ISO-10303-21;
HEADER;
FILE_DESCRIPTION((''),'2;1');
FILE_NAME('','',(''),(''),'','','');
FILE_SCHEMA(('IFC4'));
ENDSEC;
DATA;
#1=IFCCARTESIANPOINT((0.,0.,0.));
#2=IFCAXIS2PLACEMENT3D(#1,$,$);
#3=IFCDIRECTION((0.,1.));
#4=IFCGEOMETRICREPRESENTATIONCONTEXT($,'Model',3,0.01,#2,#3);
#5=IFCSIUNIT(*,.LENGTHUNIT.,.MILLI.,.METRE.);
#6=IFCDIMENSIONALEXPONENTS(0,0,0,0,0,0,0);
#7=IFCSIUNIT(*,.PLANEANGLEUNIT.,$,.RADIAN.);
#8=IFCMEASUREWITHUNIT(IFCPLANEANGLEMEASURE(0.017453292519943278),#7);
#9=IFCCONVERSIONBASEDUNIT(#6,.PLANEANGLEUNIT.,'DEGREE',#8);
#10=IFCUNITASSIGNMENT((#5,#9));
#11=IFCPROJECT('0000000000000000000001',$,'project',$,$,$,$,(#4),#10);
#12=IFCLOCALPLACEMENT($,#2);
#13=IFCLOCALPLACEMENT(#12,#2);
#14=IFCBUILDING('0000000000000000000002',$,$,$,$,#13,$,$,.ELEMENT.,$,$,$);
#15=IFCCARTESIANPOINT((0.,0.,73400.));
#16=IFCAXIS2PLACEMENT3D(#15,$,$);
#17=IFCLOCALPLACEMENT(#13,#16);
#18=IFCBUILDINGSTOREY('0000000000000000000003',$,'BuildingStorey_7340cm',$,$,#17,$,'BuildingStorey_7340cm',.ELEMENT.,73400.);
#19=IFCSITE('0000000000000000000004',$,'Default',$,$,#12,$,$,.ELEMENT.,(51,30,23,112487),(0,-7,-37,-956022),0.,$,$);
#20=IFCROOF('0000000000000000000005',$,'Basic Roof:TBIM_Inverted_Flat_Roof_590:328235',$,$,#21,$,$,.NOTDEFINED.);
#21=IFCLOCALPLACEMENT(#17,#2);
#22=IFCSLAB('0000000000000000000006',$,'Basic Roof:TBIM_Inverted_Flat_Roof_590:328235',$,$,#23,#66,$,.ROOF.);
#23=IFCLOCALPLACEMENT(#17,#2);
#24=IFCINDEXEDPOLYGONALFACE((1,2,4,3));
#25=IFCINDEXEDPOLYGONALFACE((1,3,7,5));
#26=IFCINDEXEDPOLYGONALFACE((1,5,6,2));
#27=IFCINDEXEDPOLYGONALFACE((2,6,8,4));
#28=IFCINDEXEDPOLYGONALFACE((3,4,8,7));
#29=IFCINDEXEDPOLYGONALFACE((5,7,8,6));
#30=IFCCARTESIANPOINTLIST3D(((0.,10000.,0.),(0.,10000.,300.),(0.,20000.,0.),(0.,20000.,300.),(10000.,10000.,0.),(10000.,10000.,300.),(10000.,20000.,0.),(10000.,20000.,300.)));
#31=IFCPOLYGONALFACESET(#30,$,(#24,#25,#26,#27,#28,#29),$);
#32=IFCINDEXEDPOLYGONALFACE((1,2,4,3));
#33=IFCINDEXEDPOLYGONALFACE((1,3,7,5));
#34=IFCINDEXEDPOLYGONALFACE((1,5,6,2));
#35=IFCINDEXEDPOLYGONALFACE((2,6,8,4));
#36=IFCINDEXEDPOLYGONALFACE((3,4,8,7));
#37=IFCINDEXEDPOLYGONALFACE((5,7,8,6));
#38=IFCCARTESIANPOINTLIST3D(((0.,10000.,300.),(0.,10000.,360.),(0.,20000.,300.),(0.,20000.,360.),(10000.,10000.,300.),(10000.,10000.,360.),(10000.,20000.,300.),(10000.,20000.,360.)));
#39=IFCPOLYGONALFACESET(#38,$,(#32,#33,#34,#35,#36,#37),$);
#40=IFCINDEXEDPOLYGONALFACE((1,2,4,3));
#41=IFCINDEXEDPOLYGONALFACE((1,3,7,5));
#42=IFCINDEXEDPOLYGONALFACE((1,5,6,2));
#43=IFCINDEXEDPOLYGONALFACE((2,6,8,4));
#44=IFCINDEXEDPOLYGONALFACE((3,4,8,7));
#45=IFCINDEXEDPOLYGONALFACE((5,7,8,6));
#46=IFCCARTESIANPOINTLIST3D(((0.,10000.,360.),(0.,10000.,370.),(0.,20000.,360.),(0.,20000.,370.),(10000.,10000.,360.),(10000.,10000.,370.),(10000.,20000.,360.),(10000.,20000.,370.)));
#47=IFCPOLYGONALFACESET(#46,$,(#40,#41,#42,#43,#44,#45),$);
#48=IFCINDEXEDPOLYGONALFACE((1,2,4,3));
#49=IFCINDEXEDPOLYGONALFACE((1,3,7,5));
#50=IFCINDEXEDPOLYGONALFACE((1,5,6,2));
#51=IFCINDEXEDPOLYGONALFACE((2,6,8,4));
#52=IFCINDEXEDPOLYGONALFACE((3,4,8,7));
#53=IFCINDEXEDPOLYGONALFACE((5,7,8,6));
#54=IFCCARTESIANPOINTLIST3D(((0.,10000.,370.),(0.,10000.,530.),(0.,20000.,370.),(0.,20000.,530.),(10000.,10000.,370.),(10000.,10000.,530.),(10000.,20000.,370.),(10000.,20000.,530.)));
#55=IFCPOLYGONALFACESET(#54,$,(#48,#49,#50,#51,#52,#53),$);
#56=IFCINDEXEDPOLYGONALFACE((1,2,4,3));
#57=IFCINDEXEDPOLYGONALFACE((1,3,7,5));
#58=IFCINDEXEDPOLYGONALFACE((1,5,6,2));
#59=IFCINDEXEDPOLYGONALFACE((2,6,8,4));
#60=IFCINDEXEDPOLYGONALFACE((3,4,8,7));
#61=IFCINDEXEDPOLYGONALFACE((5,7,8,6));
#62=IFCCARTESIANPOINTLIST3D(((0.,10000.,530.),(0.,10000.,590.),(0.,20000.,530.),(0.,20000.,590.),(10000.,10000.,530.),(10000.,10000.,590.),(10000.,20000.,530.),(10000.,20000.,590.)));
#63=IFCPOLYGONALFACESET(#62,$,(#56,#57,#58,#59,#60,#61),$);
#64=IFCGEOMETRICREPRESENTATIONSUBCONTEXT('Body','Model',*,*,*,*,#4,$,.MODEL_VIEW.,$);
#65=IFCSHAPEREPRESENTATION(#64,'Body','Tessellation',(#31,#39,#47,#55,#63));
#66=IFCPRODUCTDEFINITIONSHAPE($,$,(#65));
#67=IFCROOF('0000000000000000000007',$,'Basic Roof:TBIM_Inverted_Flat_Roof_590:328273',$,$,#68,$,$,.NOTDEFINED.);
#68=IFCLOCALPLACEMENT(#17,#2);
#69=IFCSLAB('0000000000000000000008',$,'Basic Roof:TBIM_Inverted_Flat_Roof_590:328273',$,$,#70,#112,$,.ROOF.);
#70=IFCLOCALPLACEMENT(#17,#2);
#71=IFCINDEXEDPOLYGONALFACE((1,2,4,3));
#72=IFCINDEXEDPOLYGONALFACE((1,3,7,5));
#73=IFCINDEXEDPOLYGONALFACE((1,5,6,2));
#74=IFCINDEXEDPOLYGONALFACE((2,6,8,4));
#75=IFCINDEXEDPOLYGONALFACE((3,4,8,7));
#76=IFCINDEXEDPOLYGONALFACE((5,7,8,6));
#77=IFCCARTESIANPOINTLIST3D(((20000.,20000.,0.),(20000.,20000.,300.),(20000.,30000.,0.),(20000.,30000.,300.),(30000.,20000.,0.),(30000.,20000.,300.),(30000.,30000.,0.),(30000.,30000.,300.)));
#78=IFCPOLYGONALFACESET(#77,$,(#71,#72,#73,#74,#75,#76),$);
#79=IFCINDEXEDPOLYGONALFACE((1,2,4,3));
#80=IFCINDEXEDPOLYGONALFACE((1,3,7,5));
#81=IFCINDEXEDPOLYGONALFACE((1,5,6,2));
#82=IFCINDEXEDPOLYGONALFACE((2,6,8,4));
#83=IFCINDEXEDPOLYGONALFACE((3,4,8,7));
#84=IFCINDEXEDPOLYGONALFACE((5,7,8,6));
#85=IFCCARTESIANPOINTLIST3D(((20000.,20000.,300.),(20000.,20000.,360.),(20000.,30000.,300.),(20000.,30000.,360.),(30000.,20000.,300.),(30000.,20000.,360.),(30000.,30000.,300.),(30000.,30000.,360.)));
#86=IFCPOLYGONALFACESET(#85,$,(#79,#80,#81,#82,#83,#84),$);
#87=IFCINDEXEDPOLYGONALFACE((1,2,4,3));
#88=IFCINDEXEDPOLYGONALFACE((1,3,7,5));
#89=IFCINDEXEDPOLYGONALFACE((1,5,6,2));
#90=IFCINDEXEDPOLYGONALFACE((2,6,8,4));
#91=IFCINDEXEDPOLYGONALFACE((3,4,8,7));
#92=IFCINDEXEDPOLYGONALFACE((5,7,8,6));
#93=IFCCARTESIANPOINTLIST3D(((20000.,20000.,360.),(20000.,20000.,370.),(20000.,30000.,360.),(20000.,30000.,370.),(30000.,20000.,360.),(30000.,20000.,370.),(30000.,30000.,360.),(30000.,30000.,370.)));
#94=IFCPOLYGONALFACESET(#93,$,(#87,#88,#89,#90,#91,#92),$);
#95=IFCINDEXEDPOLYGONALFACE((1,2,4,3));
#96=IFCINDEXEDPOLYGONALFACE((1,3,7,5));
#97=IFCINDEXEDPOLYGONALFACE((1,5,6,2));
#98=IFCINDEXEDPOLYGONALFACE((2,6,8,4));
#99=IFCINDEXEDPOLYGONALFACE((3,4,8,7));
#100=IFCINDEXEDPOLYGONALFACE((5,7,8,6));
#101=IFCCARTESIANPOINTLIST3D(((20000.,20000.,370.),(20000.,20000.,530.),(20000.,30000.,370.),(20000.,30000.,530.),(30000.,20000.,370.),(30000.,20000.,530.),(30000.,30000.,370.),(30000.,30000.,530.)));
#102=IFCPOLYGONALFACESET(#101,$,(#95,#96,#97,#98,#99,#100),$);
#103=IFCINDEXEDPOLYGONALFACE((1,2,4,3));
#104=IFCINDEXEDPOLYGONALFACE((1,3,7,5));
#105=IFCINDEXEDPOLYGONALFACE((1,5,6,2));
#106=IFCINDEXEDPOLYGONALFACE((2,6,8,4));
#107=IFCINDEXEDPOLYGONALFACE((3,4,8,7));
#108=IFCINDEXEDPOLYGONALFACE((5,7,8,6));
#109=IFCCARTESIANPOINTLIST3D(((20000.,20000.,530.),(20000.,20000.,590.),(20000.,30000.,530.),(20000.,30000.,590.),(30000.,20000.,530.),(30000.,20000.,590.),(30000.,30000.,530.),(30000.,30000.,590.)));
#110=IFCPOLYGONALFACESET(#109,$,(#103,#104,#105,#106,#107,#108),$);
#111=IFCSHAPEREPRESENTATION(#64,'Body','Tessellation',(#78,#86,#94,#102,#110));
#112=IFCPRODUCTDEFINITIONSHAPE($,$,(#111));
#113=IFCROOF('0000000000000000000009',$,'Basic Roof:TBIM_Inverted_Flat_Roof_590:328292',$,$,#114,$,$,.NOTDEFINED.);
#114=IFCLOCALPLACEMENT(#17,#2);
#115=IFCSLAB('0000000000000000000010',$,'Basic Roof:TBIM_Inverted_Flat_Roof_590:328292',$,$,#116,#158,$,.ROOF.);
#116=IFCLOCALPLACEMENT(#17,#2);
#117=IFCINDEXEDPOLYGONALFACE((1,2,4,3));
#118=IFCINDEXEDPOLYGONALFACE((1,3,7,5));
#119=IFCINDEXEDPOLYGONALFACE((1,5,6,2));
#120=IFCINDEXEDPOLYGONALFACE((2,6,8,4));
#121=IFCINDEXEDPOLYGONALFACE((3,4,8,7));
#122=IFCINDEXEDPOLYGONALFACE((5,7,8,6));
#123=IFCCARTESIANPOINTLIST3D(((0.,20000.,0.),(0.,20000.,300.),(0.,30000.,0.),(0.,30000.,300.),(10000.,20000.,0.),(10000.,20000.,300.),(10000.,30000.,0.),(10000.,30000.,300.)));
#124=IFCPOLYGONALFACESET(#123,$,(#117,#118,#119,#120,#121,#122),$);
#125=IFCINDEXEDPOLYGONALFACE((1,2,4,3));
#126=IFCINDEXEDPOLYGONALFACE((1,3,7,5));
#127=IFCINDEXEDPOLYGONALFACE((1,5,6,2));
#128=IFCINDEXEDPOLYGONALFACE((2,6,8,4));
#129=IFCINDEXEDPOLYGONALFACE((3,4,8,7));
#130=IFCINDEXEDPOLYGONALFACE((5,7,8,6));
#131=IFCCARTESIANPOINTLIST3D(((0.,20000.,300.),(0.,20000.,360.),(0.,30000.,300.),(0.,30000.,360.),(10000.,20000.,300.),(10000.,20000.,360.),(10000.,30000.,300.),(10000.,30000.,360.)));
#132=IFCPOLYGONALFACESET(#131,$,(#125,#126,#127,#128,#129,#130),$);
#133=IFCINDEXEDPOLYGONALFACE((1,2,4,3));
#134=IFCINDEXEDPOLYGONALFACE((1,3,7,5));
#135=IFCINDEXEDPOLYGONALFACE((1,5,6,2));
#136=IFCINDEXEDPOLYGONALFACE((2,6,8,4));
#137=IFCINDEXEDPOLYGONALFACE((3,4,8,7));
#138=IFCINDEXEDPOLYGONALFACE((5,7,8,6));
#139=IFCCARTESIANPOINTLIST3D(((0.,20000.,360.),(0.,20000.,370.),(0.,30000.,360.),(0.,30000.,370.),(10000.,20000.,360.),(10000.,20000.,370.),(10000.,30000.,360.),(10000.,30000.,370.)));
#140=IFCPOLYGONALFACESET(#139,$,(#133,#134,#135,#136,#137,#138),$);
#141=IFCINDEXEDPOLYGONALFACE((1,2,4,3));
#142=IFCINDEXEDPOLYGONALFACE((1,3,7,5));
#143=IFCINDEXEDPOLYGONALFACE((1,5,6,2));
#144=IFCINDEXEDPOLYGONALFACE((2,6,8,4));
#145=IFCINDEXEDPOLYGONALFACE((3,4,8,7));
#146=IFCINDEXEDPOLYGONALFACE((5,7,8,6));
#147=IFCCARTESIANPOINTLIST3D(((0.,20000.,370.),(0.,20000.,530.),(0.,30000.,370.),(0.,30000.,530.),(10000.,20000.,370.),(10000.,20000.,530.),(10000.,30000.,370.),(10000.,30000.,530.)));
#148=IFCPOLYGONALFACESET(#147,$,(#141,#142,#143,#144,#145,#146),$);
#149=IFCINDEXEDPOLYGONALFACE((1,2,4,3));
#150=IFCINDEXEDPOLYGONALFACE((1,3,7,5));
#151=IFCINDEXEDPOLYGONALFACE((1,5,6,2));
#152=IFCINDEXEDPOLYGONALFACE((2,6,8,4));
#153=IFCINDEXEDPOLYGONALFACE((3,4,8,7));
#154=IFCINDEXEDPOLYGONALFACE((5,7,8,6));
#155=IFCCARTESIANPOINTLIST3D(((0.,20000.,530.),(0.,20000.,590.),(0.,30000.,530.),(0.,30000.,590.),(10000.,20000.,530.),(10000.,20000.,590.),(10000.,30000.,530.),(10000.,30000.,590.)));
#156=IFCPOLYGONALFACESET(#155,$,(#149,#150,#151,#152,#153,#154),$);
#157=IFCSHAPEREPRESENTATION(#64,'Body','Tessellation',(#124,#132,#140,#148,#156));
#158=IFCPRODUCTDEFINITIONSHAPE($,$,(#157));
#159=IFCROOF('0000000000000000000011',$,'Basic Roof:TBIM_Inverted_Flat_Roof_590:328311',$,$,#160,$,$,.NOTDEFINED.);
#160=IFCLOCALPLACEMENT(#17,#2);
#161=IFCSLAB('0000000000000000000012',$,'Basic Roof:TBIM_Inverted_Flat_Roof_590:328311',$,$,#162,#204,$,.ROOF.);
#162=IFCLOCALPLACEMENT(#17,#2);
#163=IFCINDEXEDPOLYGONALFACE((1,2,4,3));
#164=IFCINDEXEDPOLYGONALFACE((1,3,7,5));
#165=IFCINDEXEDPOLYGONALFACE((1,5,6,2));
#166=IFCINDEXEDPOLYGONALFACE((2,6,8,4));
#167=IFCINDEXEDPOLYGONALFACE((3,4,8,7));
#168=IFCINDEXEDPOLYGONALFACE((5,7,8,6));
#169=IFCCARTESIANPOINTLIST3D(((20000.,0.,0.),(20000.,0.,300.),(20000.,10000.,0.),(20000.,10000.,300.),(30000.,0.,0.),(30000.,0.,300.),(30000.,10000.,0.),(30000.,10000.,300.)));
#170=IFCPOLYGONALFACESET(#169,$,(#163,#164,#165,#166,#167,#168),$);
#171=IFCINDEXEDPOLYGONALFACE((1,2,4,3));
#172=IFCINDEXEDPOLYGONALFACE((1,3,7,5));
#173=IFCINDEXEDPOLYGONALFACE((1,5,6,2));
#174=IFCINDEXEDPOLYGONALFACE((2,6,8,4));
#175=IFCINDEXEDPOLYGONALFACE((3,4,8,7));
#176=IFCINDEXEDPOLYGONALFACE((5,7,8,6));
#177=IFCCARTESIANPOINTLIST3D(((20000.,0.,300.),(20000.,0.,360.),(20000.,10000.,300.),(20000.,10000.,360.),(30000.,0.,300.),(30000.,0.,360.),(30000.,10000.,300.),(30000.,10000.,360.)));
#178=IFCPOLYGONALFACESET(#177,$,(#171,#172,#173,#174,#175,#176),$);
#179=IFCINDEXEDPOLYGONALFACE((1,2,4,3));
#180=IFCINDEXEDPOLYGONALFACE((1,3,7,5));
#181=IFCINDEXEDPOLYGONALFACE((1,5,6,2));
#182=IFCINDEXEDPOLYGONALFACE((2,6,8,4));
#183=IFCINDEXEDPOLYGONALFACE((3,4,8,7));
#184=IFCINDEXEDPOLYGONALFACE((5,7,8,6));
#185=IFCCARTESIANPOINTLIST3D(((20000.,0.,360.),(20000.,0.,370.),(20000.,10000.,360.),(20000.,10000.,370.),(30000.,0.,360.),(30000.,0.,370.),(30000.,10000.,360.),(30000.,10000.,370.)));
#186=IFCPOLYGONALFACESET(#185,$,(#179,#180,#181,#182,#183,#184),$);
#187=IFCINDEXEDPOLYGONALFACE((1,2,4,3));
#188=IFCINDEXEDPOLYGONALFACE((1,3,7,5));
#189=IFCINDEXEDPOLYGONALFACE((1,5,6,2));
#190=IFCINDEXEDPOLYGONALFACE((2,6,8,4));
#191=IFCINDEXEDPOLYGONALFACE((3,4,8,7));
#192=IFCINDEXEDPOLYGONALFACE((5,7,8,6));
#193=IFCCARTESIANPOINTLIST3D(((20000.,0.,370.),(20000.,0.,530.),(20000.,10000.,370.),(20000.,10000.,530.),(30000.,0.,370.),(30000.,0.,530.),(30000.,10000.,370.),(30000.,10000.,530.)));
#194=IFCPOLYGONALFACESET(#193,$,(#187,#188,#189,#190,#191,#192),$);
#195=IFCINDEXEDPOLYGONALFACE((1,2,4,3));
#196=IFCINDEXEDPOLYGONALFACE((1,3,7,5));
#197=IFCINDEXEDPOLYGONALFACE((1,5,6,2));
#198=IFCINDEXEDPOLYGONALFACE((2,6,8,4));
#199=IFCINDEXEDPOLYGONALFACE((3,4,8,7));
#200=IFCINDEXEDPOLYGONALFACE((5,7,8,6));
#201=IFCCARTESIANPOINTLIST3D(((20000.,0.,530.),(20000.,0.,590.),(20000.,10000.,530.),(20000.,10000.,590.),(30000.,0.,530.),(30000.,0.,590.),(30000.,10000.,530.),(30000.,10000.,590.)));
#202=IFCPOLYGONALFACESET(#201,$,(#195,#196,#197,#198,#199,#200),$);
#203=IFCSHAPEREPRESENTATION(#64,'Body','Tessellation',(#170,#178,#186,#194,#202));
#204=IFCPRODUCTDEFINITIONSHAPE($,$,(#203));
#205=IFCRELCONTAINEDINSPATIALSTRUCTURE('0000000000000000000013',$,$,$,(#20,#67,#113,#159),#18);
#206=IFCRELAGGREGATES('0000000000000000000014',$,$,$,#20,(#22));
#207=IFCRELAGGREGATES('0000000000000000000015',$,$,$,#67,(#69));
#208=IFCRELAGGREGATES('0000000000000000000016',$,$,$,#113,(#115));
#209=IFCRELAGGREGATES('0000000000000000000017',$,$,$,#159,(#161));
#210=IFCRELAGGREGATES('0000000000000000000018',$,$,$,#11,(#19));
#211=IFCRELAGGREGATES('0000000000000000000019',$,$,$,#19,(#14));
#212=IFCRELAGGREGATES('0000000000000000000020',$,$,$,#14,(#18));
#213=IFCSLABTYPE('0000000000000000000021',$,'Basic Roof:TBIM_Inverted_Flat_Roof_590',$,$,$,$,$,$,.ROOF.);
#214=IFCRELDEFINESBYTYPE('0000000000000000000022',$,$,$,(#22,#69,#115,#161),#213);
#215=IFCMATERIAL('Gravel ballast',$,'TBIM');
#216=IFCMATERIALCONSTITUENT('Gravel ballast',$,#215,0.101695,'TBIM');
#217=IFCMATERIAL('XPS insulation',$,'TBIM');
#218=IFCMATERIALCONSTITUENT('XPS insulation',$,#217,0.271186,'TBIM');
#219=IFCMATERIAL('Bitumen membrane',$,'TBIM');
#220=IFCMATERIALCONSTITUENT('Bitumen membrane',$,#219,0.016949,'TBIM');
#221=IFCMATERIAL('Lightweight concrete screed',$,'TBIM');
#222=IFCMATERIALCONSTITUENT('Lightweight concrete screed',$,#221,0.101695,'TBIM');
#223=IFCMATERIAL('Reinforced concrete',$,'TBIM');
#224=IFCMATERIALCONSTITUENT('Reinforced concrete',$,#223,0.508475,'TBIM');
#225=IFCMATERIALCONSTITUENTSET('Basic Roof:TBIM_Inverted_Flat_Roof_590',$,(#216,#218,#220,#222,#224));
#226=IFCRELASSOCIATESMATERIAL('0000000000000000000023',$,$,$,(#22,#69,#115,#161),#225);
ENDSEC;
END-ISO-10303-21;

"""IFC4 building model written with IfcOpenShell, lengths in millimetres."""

from ifc_helpers import new_model, entity, si_unit, converted_unit, direction, frame, origin, place, context, subcontext, project, spatial, indexed_curve, outline, extrude, material, constituent, constituent_set, type_object, element, aggregate, save


model = new_model("IFC4")

# Units and contexts
model_context = context("Model", 3, precision=0.01, world=origin(), true_north=direction((0.0, 1.0)))
body_context = subcontext(model_context, "Body", "Model", "MODEL_VIEW")
ifc_project = project(units=[si_unit("LENGTHUNIT", "METRE", prefix="MILLI"), converted_unit("PLANEANGLEUNIT", "DEGREE", entity("IfcPlaneAngleMeasure", 0.017453292519943278), si_unit("PLANEANGLEUNIT", "RADIAN"), dimensions=[0, 0, 0, 0, 0, 0, 0])], contexts=[model_context])

# Site, building, storey
site_placement = place(None, origin())
site = spatial("IfcSite", under=ifc_project, at=site_placement, Name="Default", CompositionType="ELEMENT", RefLatitude=(51, 30, 23, 112487), RefLongitude=(0, -7, -37, -956022), RefElevation=0.0)
building_placement = place(site_placement, origin())
building = spatial("IfcBuilding", under=site, at=building_placement, CompositionType="ELEMENT")
storey_placement = place(building_placement, frame((0.0, 0.0, 73400.0)))
storey = spatial("IfcBuildingStorey", under=building, at=storey_placement, Name="BuildingStorey_7340cm", LongName="BuildingStorey_7340cm", CompositionType="ELEMENT", Elevation=73400.0)

# Shared definitions
ifc_material_1 = material(Name="Reinforced concrete", Category="TBIM")

# Roofs, slabs
ifc_material_2 = material(Name="Gravel ballast", Category="TBIM")
ifc_constituent_1 = constituent(ifc_material_2, Name="Gravel ballast", Category="TBIM", fraction=0.101695)
ifc_material_3 = material(Name="XPS insulation", Category="TBIM")
ifc_constituent_2 = constituent(ifc_material_3, Name="XPS insulation", Category="TBIM", fraction=0.271186)
ifc_material_4 = material(Name="Bitumen membrane", Category="TBIM")
ifc_constituent_3 = constituent(ifc_material_4, Name="Bitumen membrane", Category="TBIM", fraction=0.016949)
ifc_material_5 = material(Name="Lightweight concrete screed", Category="TBIM")
ifc_constituent_4 = constituent(ifc_material_5, Name="Lightweight concrete screed", Category="TBIM", fraction=0.101695)
ifc_constituent_5 = constituent(ifc_material_1, Name="Reinforced concrete", Category="TBIM", fraction=0.508475)
ifc_constituent_set_1 = constituent_set(constituents=[ifc_constituent_1, ifc_constituent_2, ifc_constituent_3, ifc_constituent_4, ifc_constituent_5], Name="Basic Roof:TBIM_Inverted_Flat_Roof_590")
slab_type_1 = type_object("IfcSlabType", Name="Basic Roof:TBIM_Inverted_Flat_Roof_590", PredefinedType="ROOF")
roof_1_placement = place(storey_placement, frame((0.0, 10000.0, 0.0)))
roof_1 = element("IfcRoof", 1, at=roof_1_placement, inside=storey, Name="Basic Roof:TBIM_Inverted_Flat_Roof_590:328235", PredefinedType="NOTDEFINED")
slab_1_placement = place(roof_1_placement, origin())
slab_1 = element("IfcSlab", 2, at=slab_1_placement, type_object=slab_type_1, material=ifc_constituent_set_1, Name="Basic Roof:TBIM_Inverted_Flat_Roof_590:328235", PredefinedType="ROOF", context=body_context, shape_type="SweptSolid", body=[
    extrude(outline(indexed_curve([(5000.0, 5000.0), (-5000.0, 5000.0), (-5000.0, -5000.0), (5000.0, -5000.0), (5000.0, 5000.0)], self_intersect=False)), frame((5000.0, 5000.0, 0.0)), (0.0, 0.0, 1.0), 300.0),
    extrude(outline(indexed_curve([(5000.0, 5000.0), (-5000.0, 5000.0), (-5000.0, -5000.0), (5000.0, -5000.0), (5000.0, 5000.0)], self_intersect=False)), frame((5000.0, 5000.0, 300.0)), (0.0, 0.0, 1.0), 60.0),
    extrude(outline(indexed_curve([(5000.0, 5000.0), (-5000.0, 5000.0), (-5000.0, -5000.0), (5000.0, -5000.0), (5000.0, 5000.0)], self_intersect=False)), frame((5000.0, 5000.0, 360.0)), (0.0, 0.0, 1.0), 10.0),
    extrude(outline(indexed_curve([(5000.0, 5000.0), (-5000.0, 5000.0), (-5000.0, -5000.0), (5000.0, -5000.0), (5000.0, 5000.0)], self_intersect=False)), frame((5000.0, 5000.0, 370.0)), (0.0, 0.0, 1.0), 160.0),
    extrude(outline(indexed_curve([(5000.0, 5000.0), (-5000.0, 5000.0), (-5000.0, -5000.0), (5000.0, -5000.0), (5000.0, 5000.0)], self_intersect=False)), frame((5000.0, 5000.0, 530.0)), (0.0, 0.0, 1.0), 60.0),
])
aggregate(roof_1, [slab_1])
roof_2_placement = place(storey_placement, frame((20000.0, 20000.0, 0.0)))
roof_2 = element("IfcRoof", 3, at=roof_2_placement, inside=storey, Name="Basic Roof:TBIM_Inverted_Flat_Roof_590:328273", PredefinedType="NOTDEFINED")
slab_2_placement = place(roof_2_placement, origin())
slab_2 = element("IfcSlab", 4, at=slab_2_placement, type_object=slab_type_1, material=ifc_constituent_set_1, Name="Basic Roof:TBIM_Inverted_Flat_Roof_590:328273", PredefinedType="ROOF", context=body_context, shape_type="SweptSolid", body=[
    extrude(outline(indexed_curve([(-5000.0, 5000.0), (-5000.0, -5000.0), (5000.0, -5000.0), (5000.0, 5000.0), (-5000.0, 5000.0)], self_intersect=False)), frame((5000.0, 5000.0, 0.0)), (0.0, 0.0, 1.0), 300.0),
    extrude(outline(indexed_curve([(-5000.0, 5000.0), (-5000.0, -5000.0), (5000.0, -5000.0), (5000.0, 5000.0), (-5000.0, 5000.0)], self_intersect=False)), frame((5000.0, 5000.0, 300.0)), (0.0, 0.0, 1.0), 60.0),
    extrude(outline(indexed_curve([(-5000.0, 5000.0), (-5000.0, -5000.0), (5000.0, -5000.0), (5000.0, 5000.0), (-5000.0, 5000.0)], self_intersect=False)), frame((5000.0, 5000.0, 360.0)), (0.0, 0.0, 1.0), 10.0),
    extrude(outline(indexed_curve([(-5000.0, 5000.0), (-5000.0, -5000.0), (5000.0, -5000.0), (5000.0, 5000.0), (-5000.0, 5000.0)], self_intersect=False)), frame((5000.0, 5000.0, 370.0)), (0.0, 0.0, 1.0), 160.0),
    extrude(outline(indexed_curve([(-5000.0, 5000.0), (-5000.0, -5000.0), (5000.0, -5000.0), (5000.0, 5000.0), (-5000.0, 5000.0)], self_intersect=False)), frame((5000.0, 5000.0, 530.0)), (0.0, 0.0, 1.0), 60.0),
])
aggregate(roof_2, [slab_2])
roof_3_placement = place(storey_placement, frame((0.0, 20000.0, 0.0)))
roof_3 = element("IfcRoof", 5, at=roof_3_placement, inside=storey, Name="Basic Roof:TBIM_Inverted_Flat_Roof_590:328292", PredefinedType="NOTDEFINED")
slab_3_placement = place(roof_3_placement, origin())
slab_3 = element("IfcSlab", 6, at=slab_3_placement, type_object=slab_type_1, material=ifc_constituent_set_1, Name="Basic Roof:TBIM_Inverted_Flat_Roof_590:328292", PredefinedType="ROOF", context=body_context, shape_type="SweptSolid", body=[
    extrude(outline(indexed_curve([(-5000.0, 5000.0), (-5000.0, -5000.0), (5000.0, -5000.0), (5000.0, 5000.0), (-5000.0, 5000.0)], self_intersect=False)), frame((5000.0, 5000.0, 0.0)), (0.0, 0.0, 1.0), 300.0),
    extrude(outline(indexed_curve([(-5000.0, 5000.0), (-5000.0, -5000.0), (5000.0, -5000.0), (5000.0, 5000.0), (-5000.0, 5000.0)], self_intersect=False)), frame((5000.0, 5000.0, 300.0)), (0.0, 0.0, 1.0), 60.0),
    extrude(outline(indexed_curve([(-5000.0, 5000.0), (-5000.0, -5000.0), (5000.0, -5000.0), (5000.0, 5000.0), (-5000.0, 5000.0)], self_intersect=False)), frame((5000.0, 5000.0, 360.0)), (0.0, 0.0, 1.0), 10.0),
    extrude(outline(indexed_curve([(-5000.0, 5000.0), (-5000.0, -5000.0), (5000.0, -5000.0), (5000.0, 5000.0), (-5000.0, 5000.0)], self_intersect=False)), frame((5000.0, 5000.0, 370.0)), (0.0, 0.0, 1.0), 160.0),
    extrude(outline(indexed_curve([(-5000.0, 5000.0), (-5000.0, -5000.0), (5000.0, -5000.0), (5000.0, 5000.0), (-5000.0, 5000.0)], self_intersect=False)), frame((5000.0, 5000.0, 530.0)), (0.0, 0.0, 1.0), 60.0),
])
aggregate(roof_3, [slab_3])
roof_4_placement = place(storey_placement, frame((20000.0, 0.0, 0.0)))
roof_4 = element("IfcRoof", 7, at=roof_4_placement, inside=storey, Name="Basic Roof:TBIM_Inverted_Flat_Roof_590:328311", PredefinedType="NOTDEFINED")
slab_4_placement = place(roof_4_placement, origin())
slab_4 = element("IfcSlab", 8, at=slab_4_placement, type_object=slab_type_1, material=ifc_constituent_set_1, Name="Basic Roof:TBIM_Inverted_Flat_Roof_590:328311", PredefinedType="ROOF", context=body_context, shape_type="SweptSolid", body=[
    extrude(outline(indexed_curve([(-5000.0, 5000.0), (-5000.0, -5000.0), (5000.0, -5000.0), (5000.0, 5000.0), (-5000.0, 5000.0)], self_intersect=False)), frame((5000.0, 5000.0, 0.0)), (0.0, 0.0, 1.0), 300.0),
    extrude(outline(indexed_curve([(-5000.0, 5000.0), (-5000.0, -5000.0), (5000.0, -5000.0), (5000.0, 5000.0), (-5000.0, 5000.0)], self_intersect=False)), frame((5000.0, 5000.0, 300.0)), (0.0, 0.0, 1.0), 60.0),
    extrude(outline(indexed_curve([(-5000.0, 5000.0), (-5000.0, -5000.0), (5000.0, -5000.0), (5000.0, 5000.0), (-5000.0, 5000.0)], self_intersect=False)), frame((5000.0, 5000.0, 360.0)), (0.0, 0.0, 1.0), 10.0),
    extrude(outline(indexed_curve([(-5000.0, 5000.0), (-5000.0, -5000.0), (5000.0, -5000.0), (5000.0, 5000.0), (-5000.0, 5000.0)], self_intersect=False)), frame((5000.0, 5000.0, 370.0)), (0.0, 0.0, 1.0), 160.0),
    extrude(outline(indexed_curve([(-5000.0, 5000.0), (-5000.0, -5000.0), (5000.0, -5000.0), (5000.0, 5000.0), (-5000.0, 5000.0)], self_intersect=False)), frame((5000.0, 5000.0, 530.0)), (0.0, 0.0, 1.0), 60.0),
])
aggregate(roof_4, [slab_4])

save(model, "model.ifc")
